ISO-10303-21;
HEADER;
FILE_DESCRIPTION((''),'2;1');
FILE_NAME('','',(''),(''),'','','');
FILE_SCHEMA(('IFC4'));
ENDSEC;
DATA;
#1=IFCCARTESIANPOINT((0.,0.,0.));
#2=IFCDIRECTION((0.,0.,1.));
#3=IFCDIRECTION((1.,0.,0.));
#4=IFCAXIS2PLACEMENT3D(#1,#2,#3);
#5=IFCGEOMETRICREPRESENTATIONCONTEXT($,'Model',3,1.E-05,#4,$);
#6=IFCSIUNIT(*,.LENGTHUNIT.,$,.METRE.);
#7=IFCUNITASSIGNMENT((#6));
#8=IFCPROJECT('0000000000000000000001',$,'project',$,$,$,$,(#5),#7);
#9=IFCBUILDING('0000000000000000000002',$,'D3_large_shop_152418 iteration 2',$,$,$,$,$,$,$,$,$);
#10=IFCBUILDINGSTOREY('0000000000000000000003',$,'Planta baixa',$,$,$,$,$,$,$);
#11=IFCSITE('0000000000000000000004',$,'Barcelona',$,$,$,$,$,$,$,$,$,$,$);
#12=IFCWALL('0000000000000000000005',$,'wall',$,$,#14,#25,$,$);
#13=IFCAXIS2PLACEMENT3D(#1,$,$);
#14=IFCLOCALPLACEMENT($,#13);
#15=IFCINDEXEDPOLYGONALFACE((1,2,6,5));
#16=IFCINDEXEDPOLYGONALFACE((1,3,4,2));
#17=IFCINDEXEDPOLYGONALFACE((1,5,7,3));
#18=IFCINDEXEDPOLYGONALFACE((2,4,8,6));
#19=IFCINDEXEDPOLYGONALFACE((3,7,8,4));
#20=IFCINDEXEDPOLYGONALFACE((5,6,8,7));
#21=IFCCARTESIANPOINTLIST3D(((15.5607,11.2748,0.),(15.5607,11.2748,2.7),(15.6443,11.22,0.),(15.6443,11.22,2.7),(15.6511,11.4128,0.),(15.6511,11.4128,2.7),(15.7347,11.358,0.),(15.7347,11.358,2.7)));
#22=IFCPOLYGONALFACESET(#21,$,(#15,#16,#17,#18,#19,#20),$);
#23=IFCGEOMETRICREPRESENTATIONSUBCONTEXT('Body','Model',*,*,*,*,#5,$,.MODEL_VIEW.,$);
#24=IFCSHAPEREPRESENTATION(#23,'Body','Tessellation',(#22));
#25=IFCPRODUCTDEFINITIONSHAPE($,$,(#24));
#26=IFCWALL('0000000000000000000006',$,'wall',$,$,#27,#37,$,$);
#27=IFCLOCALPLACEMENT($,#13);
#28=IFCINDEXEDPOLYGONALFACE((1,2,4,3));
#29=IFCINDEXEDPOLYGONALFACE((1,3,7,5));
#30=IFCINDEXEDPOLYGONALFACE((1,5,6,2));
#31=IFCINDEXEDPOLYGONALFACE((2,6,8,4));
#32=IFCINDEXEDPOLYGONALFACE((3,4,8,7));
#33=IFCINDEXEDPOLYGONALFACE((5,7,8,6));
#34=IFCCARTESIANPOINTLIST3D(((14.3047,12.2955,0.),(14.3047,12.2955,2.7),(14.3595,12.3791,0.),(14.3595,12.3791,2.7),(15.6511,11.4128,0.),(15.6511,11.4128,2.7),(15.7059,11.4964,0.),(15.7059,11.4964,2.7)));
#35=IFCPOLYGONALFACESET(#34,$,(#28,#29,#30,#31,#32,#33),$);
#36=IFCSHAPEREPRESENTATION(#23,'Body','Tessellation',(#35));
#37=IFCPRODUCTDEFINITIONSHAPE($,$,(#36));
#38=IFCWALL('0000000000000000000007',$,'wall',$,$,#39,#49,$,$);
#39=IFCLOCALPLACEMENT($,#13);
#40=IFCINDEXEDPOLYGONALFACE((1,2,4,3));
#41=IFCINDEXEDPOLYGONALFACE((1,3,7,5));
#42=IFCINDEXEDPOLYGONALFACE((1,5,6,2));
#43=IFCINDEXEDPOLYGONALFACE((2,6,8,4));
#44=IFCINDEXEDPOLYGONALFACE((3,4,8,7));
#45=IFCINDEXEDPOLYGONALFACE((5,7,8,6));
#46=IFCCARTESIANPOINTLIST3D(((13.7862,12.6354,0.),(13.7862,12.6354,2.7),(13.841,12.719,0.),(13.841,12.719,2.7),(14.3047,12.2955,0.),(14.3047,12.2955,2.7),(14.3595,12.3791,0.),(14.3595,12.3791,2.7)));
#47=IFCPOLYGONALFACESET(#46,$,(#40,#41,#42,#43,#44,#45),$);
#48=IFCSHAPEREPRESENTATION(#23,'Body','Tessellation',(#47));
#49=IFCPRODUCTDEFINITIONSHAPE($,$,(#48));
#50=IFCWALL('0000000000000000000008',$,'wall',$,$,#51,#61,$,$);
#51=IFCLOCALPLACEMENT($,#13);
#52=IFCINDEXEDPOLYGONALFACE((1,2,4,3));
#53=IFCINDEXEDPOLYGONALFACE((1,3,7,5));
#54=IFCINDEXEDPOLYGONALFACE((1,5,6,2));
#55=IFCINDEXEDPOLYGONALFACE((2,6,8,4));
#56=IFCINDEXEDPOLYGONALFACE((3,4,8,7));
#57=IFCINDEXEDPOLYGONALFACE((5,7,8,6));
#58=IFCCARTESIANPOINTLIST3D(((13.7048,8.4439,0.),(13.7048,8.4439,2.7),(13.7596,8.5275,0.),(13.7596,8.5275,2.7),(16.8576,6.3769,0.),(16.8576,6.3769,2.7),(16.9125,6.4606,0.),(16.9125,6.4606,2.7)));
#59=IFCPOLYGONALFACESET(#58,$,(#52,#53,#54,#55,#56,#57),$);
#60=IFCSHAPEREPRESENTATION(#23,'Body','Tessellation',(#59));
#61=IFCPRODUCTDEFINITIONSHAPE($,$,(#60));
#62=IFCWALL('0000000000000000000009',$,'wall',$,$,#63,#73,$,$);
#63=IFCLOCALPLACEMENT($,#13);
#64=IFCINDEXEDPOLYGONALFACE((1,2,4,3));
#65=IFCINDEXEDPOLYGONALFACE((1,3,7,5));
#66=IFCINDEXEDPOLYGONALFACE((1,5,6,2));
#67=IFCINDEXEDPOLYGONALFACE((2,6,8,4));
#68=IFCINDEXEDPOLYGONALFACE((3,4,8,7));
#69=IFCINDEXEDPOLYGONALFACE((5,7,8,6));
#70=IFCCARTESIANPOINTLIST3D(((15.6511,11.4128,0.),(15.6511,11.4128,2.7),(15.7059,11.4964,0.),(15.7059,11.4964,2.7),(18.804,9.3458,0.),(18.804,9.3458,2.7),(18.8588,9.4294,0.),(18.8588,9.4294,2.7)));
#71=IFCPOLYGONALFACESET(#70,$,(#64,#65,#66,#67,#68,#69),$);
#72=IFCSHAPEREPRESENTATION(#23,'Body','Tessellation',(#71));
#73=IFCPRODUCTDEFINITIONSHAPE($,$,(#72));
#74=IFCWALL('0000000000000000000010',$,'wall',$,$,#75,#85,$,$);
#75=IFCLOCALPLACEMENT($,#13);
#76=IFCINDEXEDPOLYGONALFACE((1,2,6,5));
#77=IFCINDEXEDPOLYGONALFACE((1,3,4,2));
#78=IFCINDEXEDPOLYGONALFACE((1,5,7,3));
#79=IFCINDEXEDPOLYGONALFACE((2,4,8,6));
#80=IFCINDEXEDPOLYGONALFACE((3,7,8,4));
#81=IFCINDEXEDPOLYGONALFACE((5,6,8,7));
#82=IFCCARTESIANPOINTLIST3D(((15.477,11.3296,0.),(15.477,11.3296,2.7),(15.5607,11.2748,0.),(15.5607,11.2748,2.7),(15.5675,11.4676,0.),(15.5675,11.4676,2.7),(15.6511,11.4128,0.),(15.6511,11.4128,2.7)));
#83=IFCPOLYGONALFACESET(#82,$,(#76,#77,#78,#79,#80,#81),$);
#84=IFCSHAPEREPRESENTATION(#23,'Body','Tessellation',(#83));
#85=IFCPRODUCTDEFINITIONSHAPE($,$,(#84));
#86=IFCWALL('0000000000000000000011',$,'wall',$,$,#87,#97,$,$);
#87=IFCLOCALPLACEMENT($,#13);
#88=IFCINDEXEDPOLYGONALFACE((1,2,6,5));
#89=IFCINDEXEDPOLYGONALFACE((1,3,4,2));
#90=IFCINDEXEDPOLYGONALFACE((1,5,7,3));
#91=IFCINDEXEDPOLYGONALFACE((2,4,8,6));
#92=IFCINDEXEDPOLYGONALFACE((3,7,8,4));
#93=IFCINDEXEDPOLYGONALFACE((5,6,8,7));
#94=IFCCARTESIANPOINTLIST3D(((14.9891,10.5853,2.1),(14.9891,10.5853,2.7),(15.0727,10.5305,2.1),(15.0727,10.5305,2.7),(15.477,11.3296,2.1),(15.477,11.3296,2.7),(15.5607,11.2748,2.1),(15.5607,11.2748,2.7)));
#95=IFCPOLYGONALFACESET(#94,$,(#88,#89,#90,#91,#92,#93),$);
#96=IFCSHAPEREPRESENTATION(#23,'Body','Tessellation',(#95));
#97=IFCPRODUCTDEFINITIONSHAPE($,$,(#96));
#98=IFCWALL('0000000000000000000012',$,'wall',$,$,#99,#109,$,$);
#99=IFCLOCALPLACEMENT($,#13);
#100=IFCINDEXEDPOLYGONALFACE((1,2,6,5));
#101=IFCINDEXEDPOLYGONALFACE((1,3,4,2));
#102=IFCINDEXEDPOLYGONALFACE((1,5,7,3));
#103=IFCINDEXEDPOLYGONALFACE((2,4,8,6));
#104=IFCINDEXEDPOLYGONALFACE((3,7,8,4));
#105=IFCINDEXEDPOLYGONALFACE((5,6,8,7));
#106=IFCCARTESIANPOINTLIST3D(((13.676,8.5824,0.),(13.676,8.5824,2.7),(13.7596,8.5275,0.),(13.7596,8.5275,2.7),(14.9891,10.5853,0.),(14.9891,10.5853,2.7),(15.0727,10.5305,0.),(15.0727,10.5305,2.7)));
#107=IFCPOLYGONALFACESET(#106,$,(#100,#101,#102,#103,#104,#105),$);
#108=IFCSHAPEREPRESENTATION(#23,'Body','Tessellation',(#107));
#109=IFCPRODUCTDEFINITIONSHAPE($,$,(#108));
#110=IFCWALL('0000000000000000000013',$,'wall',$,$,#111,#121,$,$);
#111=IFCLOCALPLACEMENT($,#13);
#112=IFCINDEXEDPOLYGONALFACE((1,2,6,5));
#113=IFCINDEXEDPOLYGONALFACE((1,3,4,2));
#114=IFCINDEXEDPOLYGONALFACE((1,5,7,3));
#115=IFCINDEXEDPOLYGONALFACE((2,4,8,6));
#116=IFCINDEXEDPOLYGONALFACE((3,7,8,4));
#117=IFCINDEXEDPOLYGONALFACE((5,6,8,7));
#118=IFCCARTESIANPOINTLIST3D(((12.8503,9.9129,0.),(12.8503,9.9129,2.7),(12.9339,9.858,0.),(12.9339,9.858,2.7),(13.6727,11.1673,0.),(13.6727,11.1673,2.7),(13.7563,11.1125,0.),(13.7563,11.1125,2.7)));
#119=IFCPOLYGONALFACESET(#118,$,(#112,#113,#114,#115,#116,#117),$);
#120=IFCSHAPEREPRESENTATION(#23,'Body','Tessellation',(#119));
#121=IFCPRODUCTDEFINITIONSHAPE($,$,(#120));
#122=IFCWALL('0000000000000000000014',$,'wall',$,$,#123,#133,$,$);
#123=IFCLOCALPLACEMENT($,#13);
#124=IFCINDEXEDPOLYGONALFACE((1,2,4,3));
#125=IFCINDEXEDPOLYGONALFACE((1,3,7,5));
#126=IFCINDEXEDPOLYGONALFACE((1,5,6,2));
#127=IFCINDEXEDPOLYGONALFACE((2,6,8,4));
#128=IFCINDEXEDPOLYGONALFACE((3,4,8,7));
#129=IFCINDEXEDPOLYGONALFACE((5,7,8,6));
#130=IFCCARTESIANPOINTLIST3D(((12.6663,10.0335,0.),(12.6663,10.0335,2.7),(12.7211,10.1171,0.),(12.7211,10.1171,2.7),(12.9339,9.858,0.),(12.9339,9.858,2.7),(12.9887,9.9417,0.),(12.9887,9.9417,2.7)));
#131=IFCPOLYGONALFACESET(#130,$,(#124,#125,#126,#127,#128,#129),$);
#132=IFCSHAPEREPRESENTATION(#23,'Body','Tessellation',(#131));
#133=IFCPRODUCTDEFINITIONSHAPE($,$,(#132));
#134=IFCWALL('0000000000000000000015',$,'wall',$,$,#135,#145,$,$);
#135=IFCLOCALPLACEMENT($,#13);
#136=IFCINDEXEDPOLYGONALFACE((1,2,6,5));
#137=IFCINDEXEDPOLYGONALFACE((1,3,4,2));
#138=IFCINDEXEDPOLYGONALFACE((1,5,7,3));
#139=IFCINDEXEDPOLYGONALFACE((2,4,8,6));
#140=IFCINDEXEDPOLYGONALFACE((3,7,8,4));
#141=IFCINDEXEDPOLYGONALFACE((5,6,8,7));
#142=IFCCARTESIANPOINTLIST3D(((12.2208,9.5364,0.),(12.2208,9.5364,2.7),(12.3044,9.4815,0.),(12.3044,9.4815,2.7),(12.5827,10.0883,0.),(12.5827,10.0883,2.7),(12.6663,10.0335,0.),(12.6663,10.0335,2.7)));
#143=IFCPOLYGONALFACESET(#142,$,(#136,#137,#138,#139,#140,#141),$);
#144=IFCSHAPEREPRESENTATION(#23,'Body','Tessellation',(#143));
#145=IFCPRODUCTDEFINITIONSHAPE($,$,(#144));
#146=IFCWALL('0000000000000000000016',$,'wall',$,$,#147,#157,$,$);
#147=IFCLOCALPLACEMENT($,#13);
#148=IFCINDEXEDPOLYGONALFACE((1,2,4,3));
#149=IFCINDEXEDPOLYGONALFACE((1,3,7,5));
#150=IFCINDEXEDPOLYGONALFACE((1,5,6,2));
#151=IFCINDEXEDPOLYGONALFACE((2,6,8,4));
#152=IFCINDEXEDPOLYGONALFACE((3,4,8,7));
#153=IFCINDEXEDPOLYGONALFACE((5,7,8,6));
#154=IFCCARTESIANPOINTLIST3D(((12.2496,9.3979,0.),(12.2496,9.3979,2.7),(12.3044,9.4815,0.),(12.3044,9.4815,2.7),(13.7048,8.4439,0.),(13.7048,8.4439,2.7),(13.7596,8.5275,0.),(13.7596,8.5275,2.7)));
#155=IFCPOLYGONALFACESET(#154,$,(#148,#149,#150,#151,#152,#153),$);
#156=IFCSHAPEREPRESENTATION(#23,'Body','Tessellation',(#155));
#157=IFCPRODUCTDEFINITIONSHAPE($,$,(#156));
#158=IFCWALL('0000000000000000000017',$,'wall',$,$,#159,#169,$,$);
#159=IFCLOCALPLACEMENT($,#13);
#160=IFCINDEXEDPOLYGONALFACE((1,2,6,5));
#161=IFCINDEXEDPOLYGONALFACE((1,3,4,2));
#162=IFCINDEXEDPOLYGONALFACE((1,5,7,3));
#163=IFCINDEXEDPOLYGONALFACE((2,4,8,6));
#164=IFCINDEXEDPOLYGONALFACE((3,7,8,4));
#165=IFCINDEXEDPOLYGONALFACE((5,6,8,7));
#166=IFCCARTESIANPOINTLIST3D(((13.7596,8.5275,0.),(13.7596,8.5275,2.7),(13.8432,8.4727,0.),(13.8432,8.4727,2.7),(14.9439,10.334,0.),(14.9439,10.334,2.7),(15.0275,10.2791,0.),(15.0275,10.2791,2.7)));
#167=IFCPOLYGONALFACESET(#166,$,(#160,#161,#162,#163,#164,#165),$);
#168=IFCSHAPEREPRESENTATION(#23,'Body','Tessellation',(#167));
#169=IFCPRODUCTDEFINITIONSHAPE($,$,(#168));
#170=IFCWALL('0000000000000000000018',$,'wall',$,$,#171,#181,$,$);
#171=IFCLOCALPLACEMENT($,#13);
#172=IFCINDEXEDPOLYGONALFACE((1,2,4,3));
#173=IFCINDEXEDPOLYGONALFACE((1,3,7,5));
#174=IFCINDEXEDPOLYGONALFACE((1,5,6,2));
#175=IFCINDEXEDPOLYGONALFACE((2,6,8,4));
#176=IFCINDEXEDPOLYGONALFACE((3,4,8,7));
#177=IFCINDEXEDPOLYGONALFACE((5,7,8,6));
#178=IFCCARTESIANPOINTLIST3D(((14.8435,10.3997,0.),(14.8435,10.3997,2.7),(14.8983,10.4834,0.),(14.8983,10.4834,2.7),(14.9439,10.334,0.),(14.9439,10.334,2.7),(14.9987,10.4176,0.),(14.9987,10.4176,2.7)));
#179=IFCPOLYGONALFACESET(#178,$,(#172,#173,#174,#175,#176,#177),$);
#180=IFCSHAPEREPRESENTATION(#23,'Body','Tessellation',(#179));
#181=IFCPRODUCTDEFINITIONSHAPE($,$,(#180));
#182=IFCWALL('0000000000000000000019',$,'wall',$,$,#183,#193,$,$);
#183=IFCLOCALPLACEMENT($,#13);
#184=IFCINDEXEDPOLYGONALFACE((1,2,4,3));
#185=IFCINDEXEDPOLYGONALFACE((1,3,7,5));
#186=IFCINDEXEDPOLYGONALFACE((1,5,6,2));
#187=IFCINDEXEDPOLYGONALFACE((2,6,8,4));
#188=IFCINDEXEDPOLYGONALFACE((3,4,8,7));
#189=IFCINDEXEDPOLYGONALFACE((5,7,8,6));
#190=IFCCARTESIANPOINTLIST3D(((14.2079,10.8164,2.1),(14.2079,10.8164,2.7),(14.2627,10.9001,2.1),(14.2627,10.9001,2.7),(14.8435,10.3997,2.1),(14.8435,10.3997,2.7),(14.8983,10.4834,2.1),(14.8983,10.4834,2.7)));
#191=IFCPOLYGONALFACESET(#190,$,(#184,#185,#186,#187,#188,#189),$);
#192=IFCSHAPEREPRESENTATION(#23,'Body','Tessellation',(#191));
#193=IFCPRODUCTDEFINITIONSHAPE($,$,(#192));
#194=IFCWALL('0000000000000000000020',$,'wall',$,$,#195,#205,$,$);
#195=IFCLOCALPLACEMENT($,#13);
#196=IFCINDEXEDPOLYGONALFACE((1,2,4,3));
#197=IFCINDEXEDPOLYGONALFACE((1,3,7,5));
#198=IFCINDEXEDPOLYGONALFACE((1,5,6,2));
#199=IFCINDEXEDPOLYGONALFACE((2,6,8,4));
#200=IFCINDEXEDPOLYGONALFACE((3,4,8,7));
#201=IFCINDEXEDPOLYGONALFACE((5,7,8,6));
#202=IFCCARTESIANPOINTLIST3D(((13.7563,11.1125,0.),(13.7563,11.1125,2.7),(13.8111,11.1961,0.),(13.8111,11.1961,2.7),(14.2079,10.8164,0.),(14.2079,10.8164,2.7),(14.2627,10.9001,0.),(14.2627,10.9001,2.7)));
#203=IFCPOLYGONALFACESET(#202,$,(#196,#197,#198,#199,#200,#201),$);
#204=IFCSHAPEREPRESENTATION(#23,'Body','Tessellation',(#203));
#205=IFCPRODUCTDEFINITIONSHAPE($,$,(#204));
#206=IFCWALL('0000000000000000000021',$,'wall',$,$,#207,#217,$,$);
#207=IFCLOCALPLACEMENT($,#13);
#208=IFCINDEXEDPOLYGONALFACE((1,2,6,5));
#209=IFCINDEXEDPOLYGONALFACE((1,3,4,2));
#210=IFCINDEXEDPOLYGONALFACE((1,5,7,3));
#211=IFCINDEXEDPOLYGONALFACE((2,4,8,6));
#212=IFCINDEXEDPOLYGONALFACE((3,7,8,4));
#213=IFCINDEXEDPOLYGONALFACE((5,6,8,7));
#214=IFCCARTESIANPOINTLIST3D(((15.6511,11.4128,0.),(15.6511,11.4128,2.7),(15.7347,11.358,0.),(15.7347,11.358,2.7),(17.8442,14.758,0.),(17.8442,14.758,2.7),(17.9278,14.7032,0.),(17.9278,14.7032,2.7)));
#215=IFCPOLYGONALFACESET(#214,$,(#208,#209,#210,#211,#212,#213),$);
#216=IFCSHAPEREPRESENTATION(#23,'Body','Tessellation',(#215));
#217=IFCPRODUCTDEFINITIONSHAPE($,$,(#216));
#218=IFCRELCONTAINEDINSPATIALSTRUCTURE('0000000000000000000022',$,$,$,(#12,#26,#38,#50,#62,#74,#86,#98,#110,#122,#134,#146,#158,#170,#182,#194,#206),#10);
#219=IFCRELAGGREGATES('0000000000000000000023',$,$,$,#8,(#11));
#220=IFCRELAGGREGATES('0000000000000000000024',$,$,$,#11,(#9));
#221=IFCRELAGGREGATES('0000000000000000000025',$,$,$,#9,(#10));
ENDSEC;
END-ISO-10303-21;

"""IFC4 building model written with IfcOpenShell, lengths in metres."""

from ifc_helpers import new_model, si_unit, frame, origin, origin_with_axes, place, context, subcontext, project, spatial, polyline, outline, extrude, element, save


model = new_model("IFC4")

# Units and contexts
model_context = context("Model", 3, precision=1e-05, world=origin_with_axes())
body_context = subcontext(model_context, "Body", "Model", "MODEL_VIEW")
ifc_project = project(units=[si_unit("LENGTHUNIT", "METRE")], contexts=[model_context])

# Site, building, storey
site = spatial("IfcSite", under=ifc_project, Name="Barcelona")
building = spatial("IfcBuilding", under=site, Name="D3_large_shop_152418 iteration 2")
storey = spatial("IfcBuildingStorey", under=building, Name="Planta baixa")

# Walls
wall_1_placement = place(None, origin_with_axes())
element("IfcWall", 1, at=wall_1_placement, inside=storey, Name="wall", context=body_context, shape_type="SweptSolid", body=[
    extrude(outline(polyline([(15.5607, 11.2748), (15.6511, 11.4128), (15.7347, 11.358), (15.6443, 11.22), (15.5607, 11.2748)])), origin(), (0.0, 0.0, 1.0), 2.7),
])
wall_2_placement = place(None, origin_with_axes())
element("IfcWall", 2, at=wall_2_placement, inside=storey, Name="wall", context=body_context, shape_type="SweptSolid", body=[
    extrude(outline(polyline([(15.6511, 11.4128), (14.3047, 12.2955), (14.3595, 12.3791), (15.7059, 11.4964), (15.6511, 11.4128)])), origin(), (0.0, 0.0, 1.0), 2.7),
])
wall_3_placement = place(None, origin_with_axes())
element("IfcWall", 3, at=wall_3_placement, inside=storey, Name="wall", context=body_context, shape_type="SweptSolid", body=[
    extrude(outline(polyline([(14.3047, 12.2955), (13.7862, 12.6354), (13.841, 12.719), (14.3595, 12.3791), (14.3047, 12.2955)])), origin(), (0.0, 0.0, 1.0), 2.7),
])
wall_4_placement = place(None, origin_with_axes())
element("IfcWall", 4, at=wall_4_placement, inside=storey, Name="wall", context=body_context, shape_type="SweptSolid", body=[
    extrude(outline(polyline([(13.7596, 8.5275), (16.9125, 6.4606), (16.8576, 6.3769), (13.7048, 8.4439), (13.7596, 8.5275)])), origin(), (0.0, 0.0, 1.0), 2.7),
])
wall_5_placement = place(None, origin_with_axes())
element("IfcWall", 5, at=wall_5_placement, inside=storey, Name="wall", context=body_context, shape_type="SweptSolid", body=[
    extrude(outline(polyline([(18.804, 9.3458), (15.6511, 11.4128), (15.7059, 11.4964), (18.8588, 9.4294), (18.804, 9.3458)])), origin(), (0.0, 0.0, 1.0), 2.7),
])
wall_6_placement = place(None, origin_with_axes())
element("IfcWall", 6, at=wall_6_placement, inside=storey, Name="wall", context=body_context, shape_type="SweptSolid", body=[
    extrude(outline(polyline([(15.6511, 11.4128), (15.5607, 11.2748), (15.477, 11.3296), (15.5675, 11.4676), (15.6511, 11.4128)])), origin(), (0.0, 0.0, 1.0), 2.7),
])
wall_7_placement = place(None, origin_with_axes())
element("IfcWall", 7, at=wall_7_placement, inside=storey, Name="wall", context=body_context, shape_type="SweptSolid", body=[
    extrude(outline(polyline([(15.5607, 11.2748), (15.0727, 10.5305), (14.9891, 10.5853), (15.477, 11.3296), (15.5607, 11.2748)])), frame((0.0, 0.0, 2.1)), (0.0, 0.0, 1.0), 0.6),
])
wall_8_placement = place(None, origin_with_axes())
element("IfcWall", 8, at=wall_8_placement, inside=storey, Name="wall", context=body_context, shape_type="SweptSolid", body=[
    extrude(outline(polyline([(15.0727, 10.5305), (13.7596, 8.5275), (13.676, 8.5824), (14.9891, 10.5853), (15.0727, 10.5305)])), origin(), (0.0, 0.0, 1.0), 2.7),
])
wall_9_placement = place(None, origin_with_axes())
element("IfcWall", 9, at=wall_9_placement, inside=storey, Name="wall", context=body_context, shape_type="SweptSolid", body=[
    extrude(outline(polyline([(13.7563, 11.1125), (12.9339, 9.858), (12.8503, 9.9129), (13.6727, 11.1673), (13.7563, 11.1125)])), origin(), (0.0, 0.0, 1.0), 2.7),
])
wall_10_placement = place(None, origin_with_axes())
element("IfcWall", 10, at=wall_10_placement, inside=storey, Name="wall", context=body_context, shape_type="SweptSolid", body=[
    extrude(outline(polyline([(12.9339, 9.858), (12.6663, 10.0335), (12.7211, 10.1171), (12.9887, 9.9417), (12.9339, 9.858)])), origin(), (0.0, 0.0, 1.0), 2.7),
])
wall_11_placement = place(None, origin_with_axes())
element("IfcWall", 11, at=wall_11_placement, inside=storey, Name="wall", context=body_context, shape_type="SweptSolid", body=[
    extrude(outline(polyline([(12.6663, 10.0335), (12.3044, 9.4815), (12.2208, 9.5364), (12.5827, 10.0883), (12.6663, 10.0335)])), origin(), (0.0, 0.0, 1.0), 2.7),
])
wall_12_placement = place(None, origin_with_axes())
element("IfcWall", 12, at=wall_12_placement, inside=storey, Name="wall", context=body_context, shape_type="SweptSolid", body=[
    extrude(outline(polyline([(12.3044, 9.4815), (13.7596, 8.5275), (13.7048, 8.4439), (12.2496, 9.3979), (12.3044, 9.4815)])), origin(), (0.0, 0.0, 1.0), 2.7),
])
wall_13_placement = place(None, origin_with_axes())
element("IfcWall", 13, at=wall_13_placement, inside=storey, Name="wall", context=body_context, shape_type="SweptSolid", body=[
    extrude(outline(polyline([(13.7596, 8.5275), (14.9439, 10.334), (15.0275, 10.2791), (13.8432, 8.4727), (13.7596, 8.5275)])), origin(), (0.0, 0.0, 1.0), 2.7),
])
wall_14_placement = place(None, origin_with_axes())
element("IfcWall", 14, at=wall_14_placement, inside=storey, Name="wall", context=body_context, shape_type="SweptSolid", body=[
    extrude(outline(polyline([(14.9439, 10.334), (14.8435, 10.3997), (14.8983, 10.4834), (14.9987, 10.4176), (14.9439, 10.334)])), origin(), (0.0, 0.0, 1.0), 2.7),
])
wall_15_placement = place(None, origin_with_axes())
element("IfcWall", 15, at=wall_15_placement, inside=storey, Name="wall", context=body_context, shape_type="SweptSolid", body=[
    extrude(outline(polyline([(14.8435, 10.3997), (14.2079, 10.8164), (14.2627, 10.9001), (14.8983, 10.4834), (14.8435, 10.3997)])), frame((0.0, 0.0, 2.1)), (0.0, 0.0, 1.0), 0.6),
])
wall_16_placement = place(None, origin_with_axes())
element("IfcWall", 16, at=wall_16_placement, inside=storey, Name="wall", context=body_context, shape_type="SweptSolid", body=[
    extrude(outline(polyline([(14.2079, 10.8164), (13.7563, 11.1125), (13.8111, 11.1961), (14.2627, 10.9001), (14.2079, 10.8164)])), origin(), (0.0, 0.0, 1.0), 2.7),
])
wall_17_placement = place(None, origin_with_axes())
element("IfcWall", 17, at=wall_17_placement, inside=storey, Name="wall", context=body_context, shape_type="SweptSolid", body=[
    extrude(outline(polyline([(15.6511, 11.4128), (17.8442, 14.758), (17.9278, 14.7032), (15.7347, 11.358), (15.6511, 11.4128)])), origin(), (0.0, 0.0, 1.0), 2.7),
])

save(model, "model.ifc")
